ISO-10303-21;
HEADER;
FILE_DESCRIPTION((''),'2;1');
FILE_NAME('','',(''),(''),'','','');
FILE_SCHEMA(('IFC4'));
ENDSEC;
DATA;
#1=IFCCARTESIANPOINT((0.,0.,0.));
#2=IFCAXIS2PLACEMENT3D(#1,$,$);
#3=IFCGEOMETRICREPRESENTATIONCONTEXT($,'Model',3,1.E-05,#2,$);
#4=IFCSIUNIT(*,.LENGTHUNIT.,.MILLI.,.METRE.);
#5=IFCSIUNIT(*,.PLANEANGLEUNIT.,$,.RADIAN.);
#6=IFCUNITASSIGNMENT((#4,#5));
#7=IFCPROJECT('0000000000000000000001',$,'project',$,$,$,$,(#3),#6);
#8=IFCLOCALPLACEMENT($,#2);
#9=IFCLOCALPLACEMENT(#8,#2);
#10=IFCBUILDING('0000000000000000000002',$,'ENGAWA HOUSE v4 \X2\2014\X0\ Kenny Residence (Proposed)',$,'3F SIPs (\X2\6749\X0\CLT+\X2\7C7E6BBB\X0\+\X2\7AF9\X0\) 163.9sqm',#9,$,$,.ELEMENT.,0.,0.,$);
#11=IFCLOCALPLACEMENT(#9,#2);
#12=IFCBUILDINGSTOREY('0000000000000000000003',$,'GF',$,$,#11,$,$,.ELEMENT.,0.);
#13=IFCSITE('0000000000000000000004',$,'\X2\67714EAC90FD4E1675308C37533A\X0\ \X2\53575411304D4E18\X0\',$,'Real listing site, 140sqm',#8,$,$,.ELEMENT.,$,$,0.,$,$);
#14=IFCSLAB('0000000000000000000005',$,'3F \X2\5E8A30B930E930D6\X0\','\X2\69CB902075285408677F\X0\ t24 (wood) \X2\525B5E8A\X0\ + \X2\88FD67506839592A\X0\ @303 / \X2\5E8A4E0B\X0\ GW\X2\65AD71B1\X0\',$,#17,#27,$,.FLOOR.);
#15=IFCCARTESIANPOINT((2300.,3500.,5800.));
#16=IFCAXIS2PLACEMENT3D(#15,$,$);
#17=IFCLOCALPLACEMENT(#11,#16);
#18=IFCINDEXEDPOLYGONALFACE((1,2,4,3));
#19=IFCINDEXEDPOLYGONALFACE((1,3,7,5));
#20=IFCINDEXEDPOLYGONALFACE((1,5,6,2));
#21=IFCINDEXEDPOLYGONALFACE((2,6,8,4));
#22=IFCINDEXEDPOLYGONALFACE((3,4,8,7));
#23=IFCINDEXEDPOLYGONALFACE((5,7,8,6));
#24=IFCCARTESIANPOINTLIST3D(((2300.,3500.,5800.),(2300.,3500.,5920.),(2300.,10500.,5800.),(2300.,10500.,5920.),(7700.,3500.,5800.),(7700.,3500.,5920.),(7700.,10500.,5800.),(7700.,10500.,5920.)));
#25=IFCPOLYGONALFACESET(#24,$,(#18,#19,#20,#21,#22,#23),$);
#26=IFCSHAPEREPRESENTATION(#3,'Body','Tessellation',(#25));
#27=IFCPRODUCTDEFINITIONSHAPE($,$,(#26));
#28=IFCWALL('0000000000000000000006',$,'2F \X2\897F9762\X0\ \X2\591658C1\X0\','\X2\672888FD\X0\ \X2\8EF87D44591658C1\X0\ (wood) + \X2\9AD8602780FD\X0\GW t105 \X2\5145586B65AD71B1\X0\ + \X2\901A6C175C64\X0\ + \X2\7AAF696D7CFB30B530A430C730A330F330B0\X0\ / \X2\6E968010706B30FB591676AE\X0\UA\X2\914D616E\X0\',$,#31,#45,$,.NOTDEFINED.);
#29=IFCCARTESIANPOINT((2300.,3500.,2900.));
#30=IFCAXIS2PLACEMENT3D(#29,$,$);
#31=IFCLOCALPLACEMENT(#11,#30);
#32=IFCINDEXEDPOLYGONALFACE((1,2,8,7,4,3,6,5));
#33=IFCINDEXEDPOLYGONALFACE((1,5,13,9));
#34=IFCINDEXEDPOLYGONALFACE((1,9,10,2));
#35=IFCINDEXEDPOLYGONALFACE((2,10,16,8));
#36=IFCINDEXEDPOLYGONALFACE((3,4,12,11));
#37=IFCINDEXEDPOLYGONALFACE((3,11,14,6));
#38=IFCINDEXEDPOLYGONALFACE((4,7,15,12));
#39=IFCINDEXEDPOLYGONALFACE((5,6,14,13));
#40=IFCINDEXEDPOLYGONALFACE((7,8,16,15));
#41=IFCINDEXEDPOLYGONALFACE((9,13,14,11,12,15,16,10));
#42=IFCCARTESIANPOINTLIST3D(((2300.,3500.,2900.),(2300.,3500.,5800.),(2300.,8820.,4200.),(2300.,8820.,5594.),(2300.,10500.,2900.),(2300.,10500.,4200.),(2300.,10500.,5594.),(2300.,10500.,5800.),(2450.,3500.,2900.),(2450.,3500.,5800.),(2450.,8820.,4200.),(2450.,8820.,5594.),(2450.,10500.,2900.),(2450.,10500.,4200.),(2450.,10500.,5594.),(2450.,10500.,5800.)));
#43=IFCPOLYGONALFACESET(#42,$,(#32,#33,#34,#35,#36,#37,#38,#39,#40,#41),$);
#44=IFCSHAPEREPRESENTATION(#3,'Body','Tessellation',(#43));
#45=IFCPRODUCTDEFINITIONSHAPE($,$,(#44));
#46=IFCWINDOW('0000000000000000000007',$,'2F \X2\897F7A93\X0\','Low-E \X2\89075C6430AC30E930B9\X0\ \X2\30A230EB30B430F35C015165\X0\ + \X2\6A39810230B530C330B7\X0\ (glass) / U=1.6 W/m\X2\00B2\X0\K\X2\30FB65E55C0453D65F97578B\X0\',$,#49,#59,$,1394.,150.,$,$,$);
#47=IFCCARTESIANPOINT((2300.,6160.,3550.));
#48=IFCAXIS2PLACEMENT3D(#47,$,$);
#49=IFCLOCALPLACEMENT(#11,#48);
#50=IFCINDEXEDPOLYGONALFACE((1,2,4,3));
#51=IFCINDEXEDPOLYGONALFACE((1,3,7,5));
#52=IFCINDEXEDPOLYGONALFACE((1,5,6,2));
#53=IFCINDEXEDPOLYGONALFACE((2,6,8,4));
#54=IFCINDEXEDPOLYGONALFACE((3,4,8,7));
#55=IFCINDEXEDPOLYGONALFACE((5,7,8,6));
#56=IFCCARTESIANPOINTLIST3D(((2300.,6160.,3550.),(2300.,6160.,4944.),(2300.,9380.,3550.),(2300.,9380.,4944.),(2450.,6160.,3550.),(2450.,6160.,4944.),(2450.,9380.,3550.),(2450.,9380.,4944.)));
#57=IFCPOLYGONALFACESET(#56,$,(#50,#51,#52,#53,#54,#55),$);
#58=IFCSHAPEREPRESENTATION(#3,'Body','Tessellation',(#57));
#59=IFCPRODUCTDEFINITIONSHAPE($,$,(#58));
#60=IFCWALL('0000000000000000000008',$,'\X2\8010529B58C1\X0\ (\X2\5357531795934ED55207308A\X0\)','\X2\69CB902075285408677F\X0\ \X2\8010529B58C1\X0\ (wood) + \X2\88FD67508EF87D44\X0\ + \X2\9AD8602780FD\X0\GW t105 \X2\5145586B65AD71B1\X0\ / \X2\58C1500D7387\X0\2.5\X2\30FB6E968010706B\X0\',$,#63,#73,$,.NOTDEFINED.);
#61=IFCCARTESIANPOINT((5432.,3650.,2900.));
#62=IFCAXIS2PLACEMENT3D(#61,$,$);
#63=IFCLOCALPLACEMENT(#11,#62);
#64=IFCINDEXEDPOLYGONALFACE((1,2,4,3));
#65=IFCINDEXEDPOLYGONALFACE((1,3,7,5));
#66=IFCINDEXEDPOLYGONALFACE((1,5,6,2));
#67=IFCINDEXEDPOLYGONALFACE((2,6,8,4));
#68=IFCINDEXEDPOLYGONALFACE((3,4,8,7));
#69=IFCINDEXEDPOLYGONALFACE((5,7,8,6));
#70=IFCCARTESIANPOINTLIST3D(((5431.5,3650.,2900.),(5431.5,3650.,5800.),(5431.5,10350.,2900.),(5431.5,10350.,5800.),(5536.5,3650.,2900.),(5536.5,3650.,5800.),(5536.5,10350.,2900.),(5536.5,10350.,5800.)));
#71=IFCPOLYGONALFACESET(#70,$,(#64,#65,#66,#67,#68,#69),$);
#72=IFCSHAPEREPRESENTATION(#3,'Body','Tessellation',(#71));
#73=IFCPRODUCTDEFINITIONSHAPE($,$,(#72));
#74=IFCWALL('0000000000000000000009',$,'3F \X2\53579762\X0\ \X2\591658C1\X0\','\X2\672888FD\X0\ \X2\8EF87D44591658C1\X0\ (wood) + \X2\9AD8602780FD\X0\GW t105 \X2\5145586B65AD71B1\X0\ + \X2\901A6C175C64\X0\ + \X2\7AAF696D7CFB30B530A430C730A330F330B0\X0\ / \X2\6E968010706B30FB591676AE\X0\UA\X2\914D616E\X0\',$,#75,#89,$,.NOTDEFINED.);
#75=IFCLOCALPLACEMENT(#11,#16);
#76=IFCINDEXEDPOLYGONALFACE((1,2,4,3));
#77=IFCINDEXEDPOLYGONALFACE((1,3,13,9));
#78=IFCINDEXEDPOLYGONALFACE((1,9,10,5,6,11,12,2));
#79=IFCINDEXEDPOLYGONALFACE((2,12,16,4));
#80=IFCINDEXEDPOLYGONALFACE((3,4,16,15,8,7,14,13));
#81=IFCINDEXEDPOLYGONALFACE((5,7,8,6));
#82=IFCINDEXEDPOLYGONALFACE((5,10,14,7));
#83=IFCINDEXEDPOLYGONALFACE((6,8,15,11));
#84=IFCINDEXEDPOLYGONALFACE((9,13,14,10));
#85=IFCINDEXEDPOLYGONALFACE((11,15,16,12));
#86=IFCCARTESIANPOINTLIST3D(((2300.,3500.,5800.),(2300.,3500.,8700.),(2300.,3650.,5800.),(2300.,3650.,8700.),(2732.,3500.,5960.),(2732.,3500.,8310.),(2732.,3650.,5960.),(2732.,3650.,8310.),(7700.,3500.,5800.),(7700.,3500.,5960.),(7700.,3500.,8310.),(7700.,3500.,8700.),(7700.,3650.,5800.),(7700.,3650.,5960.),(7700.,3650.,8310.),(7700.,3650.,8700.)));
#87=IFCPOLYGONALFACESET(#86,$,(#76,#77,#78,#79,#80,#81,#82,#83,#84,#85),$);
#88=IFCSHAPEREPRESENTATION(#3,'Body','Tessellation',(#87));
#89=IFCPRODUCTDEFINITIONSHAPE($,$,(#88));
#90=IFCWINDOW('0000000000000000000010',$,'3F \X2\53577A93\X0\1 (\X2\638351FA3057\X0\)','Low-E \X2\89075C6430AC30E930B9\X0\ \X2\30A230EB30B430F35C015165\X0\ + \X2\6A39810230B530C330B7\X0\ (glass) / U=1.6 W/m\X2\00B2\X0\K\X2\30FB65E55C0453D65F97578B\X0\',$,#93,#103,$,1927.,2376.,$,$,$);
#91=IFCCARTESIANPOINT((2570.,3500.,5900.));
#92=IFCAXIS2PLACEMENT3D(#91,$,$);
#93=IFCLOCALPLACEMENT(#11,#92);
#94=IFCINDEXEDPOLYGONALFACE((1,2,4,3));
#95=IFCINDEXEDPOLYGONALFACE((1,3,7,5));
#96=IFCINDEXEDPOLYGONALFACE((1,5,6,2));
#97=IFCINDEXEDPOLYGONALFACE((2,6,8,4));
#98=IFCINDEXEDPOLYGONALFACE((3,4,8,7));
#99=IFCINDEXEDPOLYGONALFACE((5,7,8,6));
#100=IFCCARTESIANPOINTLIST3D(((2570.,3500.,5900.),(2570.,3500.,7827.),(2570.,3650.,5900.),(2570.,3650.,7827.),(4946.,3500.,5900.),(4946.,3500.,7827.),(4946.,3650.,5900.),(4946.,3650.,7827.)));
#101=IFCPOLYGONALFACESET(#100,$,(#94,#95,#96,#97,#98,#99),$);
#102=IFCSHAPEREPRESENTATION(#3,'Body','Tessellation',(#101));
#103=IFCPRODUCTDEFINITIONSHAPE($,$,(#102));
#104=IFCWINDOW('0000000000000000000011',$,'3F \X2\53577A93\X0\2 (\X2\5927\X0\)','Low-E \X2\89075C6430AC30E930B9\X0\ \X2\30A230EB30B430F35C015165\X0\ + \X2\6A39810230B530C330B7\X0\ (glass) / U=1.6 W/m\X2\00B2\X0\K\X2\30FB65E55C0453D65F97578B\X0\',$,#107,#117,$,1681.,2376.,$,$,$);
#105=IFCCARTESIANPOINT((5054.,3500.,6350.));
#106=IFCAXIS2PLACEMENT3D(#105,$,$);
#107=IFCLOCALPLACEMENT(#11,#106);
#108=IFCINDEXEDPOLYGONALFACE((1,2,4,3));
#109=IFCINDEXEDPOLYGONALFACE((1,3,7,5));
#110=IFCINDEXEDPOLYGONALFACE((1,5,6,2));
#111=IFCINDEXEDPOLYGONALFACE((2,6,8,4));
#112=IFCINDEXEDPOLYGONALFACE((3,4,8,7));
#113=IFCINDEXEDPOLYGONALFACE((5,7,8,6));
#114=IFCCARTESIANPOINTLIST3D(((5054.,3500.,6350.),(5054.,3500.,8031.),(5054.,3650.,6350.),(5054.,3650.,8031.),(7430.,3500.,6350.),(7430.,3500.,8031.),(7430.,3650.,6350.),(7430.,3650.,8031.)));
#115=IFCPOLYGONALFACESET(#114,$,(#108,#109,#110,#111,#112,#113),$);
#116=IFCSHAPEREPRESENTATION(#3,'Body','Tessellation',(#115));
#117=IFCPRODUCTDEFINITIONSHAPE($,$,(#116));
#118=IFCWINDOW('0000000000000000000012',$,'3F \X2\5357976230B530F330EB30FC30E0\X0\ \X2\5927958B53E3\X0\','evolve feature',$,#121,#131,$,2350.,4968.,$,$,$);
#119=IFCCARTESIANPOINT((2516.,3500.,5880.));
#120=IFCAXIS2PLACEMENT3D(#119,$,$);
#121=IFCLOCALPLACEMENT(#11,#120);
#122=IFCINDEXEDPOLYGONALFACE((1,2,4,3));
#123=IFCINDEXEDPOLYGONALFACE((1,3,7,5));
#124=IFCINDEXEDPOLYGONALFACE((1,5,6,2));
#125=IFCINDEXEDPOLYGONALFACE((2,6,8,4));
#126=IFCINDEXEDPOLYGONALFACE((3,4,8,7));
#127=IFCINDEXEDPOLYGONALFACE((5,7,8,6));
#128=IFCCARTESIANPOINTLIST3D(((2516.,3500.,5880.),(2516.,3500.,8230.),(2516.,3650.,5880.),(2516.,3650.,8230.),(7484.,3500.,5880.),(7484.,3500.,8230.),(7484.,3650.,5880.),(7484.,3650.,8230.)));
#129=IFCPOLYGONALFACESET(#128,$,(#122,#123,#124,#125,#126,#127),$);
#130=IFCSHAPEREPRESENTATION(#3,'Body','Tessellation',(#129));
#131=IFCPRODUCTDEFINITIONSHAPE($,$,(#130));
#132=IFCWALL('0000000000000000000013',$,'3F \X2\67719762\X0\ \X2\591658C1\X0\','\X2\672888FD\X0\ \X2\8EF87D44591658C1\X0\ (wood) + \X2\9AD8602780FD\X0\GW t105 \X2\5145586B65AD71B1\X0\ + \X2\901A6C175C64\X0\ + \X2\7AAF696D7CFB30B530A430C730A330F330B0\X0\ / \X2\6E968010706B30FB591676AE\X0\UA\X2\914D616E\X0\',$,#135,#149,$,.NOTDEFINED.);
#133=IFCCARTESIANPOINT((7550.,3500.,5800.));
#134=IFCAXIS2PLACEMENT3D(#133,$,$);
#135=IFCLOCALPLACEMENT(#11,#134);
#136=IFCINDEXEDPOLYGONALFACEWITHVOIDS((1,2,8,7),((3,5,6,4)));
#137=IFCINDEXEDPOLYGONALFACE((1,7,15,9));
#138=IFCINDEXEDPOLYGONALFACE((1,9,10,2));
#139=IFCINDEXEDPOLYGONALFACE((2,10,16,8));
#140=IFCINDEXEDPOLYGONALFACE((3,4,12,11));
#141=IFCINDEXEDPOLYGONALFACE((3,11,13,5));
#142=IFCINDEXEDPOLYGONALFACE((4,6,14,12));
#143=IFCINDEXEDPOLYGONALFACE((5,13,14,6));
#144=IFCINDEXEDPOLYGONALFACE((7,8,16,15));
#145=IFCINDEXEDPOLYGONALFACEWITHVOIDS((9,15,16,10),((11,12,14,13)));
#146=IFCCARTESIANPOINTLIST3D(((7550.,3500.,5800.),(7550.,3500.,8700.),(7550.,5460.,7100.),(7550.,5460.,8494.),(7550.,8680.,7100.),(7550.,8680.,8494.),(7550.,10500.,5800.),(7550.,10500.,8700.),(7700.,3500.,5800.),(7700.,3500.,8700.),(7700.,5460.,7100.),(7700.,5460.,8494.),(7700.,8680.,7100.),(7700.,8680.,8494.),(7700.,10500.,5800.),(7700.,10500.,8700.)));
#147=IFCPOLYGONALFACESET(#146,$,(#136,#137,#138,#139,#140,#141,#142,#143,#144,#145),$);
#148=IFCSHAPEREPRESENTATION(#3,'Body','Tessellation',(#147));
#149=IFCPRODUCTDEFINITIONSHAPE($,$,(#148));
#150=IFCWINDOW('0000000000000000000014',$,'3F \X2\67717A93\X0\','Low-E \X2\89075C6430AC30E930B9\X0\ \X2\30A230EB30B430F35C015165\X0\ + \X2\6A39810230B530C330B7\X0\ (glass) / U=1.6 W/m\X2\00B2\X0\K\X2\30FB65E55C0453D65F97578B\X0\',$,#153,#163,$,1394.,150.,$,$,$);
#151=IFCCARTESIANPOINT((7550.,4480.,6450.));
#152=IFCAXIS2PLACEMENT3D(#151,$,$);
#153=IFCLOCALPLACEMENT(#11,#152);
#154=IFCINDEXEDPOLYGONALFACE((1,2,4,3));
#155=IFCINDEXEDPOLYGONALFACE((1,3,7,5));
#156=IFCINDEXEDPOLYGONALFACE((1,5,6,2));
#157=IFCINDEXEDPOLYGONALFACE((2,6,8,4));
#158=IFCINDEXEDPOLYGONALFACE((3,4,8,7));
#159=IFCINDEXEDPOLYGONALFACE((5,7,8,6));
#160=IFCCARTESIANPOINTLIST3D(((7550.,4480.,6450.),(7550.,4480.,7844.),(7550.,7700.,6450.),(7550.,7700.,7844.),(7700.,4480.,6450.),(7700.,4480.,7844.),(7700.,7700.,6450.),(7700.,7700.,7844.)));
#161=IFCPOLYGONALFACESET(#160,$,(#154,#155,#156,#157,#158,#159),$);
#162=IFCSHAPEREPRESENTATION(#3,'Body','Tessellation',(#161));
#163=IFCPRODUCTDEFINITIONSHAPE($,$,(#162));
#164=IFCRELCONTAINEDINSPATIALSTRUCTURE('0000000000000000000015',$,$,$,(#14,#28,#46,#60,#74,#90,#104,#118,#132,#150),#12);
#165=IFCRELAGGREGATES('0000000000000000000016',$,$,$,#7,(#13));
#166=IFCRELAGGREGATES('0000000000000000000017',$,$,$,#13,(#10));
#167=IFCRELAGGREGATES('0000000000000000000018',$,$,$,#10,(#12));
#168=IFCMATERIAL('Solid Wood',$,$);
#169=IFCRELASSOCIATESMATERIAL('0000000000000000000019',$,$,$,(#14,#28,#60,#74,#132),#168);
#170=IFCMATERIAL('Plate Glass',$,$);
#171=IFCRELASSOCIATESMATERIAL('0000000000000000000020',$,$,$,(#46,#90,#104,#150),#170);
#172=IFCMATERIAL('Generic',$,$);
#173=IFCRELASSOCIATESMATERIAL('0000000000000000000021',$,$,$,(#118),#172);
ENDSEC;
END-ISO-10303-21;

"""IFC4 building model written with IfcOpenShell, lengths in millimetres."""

from ifc_helpers import new_model, si_unit, frame, frame_2d, origin, place, context, project, spatial, rectangle, extrude, material, element, fill, save


model = new_model("IFC4")

# Units and contexts
model_context = context("Model", 3, precision=1e-05, world=origin())
ifc_project = project(units=[si_unit("LENGTHUNIT", "METRE", prefix="MILLI"), si_unit("PLANEANGLEUNIT", "RADIAN")], contexts=[model_context])

# Site, building, storey
site_placement = place(None, origin())
site = spatial("IfcSite", under=ifc_project, at=site_placement, Name="東京都世田谷区 南向き丘", ObjectType="Real listing site, 140sqm", CompositionType="ELEMENT", RefElevation=0.0)
building_placement = place(site_placement, origin())
building = spatial("IfcBuilding", under=site, at=building_placement, Name="ENGAWA HOUSE v4 — Kenny Residence (Proposed)", ObjectType="3F SIPs (杉CLT+籾殻+竹) 163.9sqm", CompositionType="ELEMENT", ElevationOfRefHeight=0.0, ElevationOfTerrain=0.0)
storey_placement = place(building_placement, origin())
storey = spatial("IfcBuildingStorey", under=building, at=storey_placement, Name="GF", CompositionType="ELEMENT", Elevation=0.0)

# Slab
ifc_material_1 = material(Name="Solid Wood")
slab_placement = place(storey_placement, frame((2300.0, 3500.0, 5800.0)))
element("IfcSlab", 1, at=slab_placement, inside=storey, material=ifc_material_1, Name="3F 床スラブ", Description="構造用合板 t24 (wood) 剛床 + 製材根太 @303 / 床下 GW断熱", PredefinedType="FLOOR", context=model_context, shape_type="SweptSolid", body=[
    extrude(rectangle(XDim=5400.0, YDim=7000.0, at=frame_2d((2700.0, 3500.0))), frame((2300.0, 3500.0, 5800.0)), (0.0, 0.0, 1.0), 120.0),
])

# Wall, opening, window
wall_1_placement = place(storey_placement, frame((2300.0, 3500.0, 2900.0)))
wall_1 = element("IfcWall", 2, at=wall_1_placement, inside=storey, material=ifc_material_1, Name="2F 西面 外壁", Description="木製 軸組外壁 (wood) + 高性能GW t105 充填断熱 + 通気層 + 窯業系サイディング / 準耐火・外皮UA配慮", PredefinedType="NOTDEFINED", context=model_context, shape_type="SweptSolid", body=[
    extrude(rectangle(XDim=150.0, YDim=7000.0, at=frame_2d((75.0, 3500.0))), frame((2300.0, 3500.0, 2900.0)), (0.0, 0.0, 1.0), 2900.0),
])
opening_1_placement = place(storey_placement, frame((2300.0, 6160.0, 3550.0)))
opening_1 = element("IfcOpeningElement", 3, at=opening_1_placement, cuts=wall_1, PredefinedType="NOTDEFINED", context=model_context, shape_type="SweptSolid", body=[
    extrude(rectangle(XDim=150.0, YDim=3220.0, at=frame_2d((75.0, 1610.0))), frame((2300.0, 6160.0, 3550.0)), (0.0, 0.0, 1.0), 1394.0),
])
ifc_material_2 = material(Name="Plate Glass")
window_1_placement = place(storey_placement, frame((2300.0, 6160.0, 3550.0)))
window_1 = element("IfcWindow", 4, at=window_1_placement, inside=storey, material=ifc_material_2, Name="2F 西窓", Description="Low-E 複層ガラス アルゴン封入 + 樹脂サッシ (glass) / U=1.6 W/m²K・日射取得型", OverallHeight=1394.0, OverallWidth=150.0, context=model_context, shape_type="SweptSolid", body=[
    extrude(rectangle(XDim=150.0, YDim=3220.0, at=frame_2d((75.0, 1610.0))), frame((2300.0, 6160.0, 3550.0)), (0.0, 0.0, 1.0), 1394.0),
])
fill(opening_1, window_1)

# Wall
wall_2_placement = place(storey_placement, frame((5432.0, 3650.0, 2900.0)))
element("IfcWall", 5, at=wall_2_placement, inside=storey, material=ifc_material_1, Name="耐力壁 (南北間仕切り)", Description="構造用合板 耐力壁 (wood) + 製材軸組 + 高性能GW t105 充填断熱 / 壁倍率2.5・準耐火", PredefinedType="NOTDEFINED", context=model_context, shape_type="SweptSolid", body=[
    extrude(rectangle(XDim=105.0, YDim=6700.0, at=frame_2d((52.0, 3350.0))), frame((5432.0, 3650.0, 2900.0)), (0.0, 0.0, 1.0), 2900.0),
])

# Wall, openings, windows
wall_3_placement = place(storey_placement, frame((2300.0, 3500.0, 5800.0)))
wall_3 = element("IfcWall", 6, at=wall_3_placement, inside=storey, material=ifc_material_1, Name="3F 南面 外壁", Description="木製 軸組外壁 (wood) + 高性能GW t105 充填断熱 + 通気層 + 窯業系サイディング / 準耐火・外皮UA配慮", PredefinedType="NOTDEFINED", context=model_context, shape_type="SweptSolid", body=[
    extrude(rectangle(XDim=5400.0, YDim=150.0, at=frame_2d((2700.0, 75.0))), frame((2300.0, 3500.0, 5800.0)), (0.0, 0.0, 1.0), 2900.0),
])
opening_2_placement = place(storey_placement, frame((2570.0, 3500.0, 5900.0)))
opening_2 = element("IfcOpeningElement", 7, at=opening_2_placement, cuts=wall_3, PredefinedType="NOTDEFINED", context=model_context, shape_type="SweptSolid", body=[
    extrude(rectangle(XDim=2376.0, YDim=150.0, at=frame_2d((1188.0, 75.0))), frame((2570.0, 3500.0, 5900.0)), (0.0, 0.0, 1.0), 1927.0),
])
opening_3_placement = place(storey_placement, frame((5054.0, 3500.0, 6350.0)))
opening_3 = element("IfcOpeningElement", 8, at=opening_3_placement, cuts=wall_3, PredefinedType="NOTDEFINED", context=model_context, shape_type="SweptSolid", body=[
    extrude(rectangle(XDim=2376.0, YDim=150.0, at=frame_2d((1188.0, 75.0))), frame((5054.0, 3500.0, 6350.0)), (0.0, 0.0, 1.0), 1681.0),
])
opening_4_placement = place(storey_placement, frame((2516.0, 3500.0, 5880.0)))
opening_4 = element("IfcOpeningElement", 9, at=opening_4_placement, cuts=wall_3, PredefinedType="NOTDEFINED", context=model_context, shape_type="SweptSolid", body=[
    extrude(rectangle(XDim=4968.0, YDim=150.0, at=frame_2d((2484.0, 75.0))), frame((2516.0, 3500.0, 5880.0)), (0.0, 0.0, 1.0), 2350.0),
])
window_2_placement = place(storey_placement, frame((2570.0, 3500.0, 5900.0)))
window_2 = element("IfcWindow", 10, at=window_2_placement, inside=storey, material=ifc_material_2, Name="3F 南窓1 (掃出し)", Description="Low-E 複層ガラス アルゴン封入 + 樹脂サッシ (glass) / U=1.6 W/m²K・日射取得型", OverallHeight=1927.0, OverallWidth=2376.0, context=model_context, shape_type="SweptSolid", body=[
    extrude(rectangle(XDim=2376.0, YDim=150.0, at=frame_2d((1188.0, 75.0))), frame((2570.0, 3500.0, 5900.0)), (0.0, 0.0, 1.0), 1927.0),
])
fill(opening_2, window_2)
window_3_placement = place(storey_placement, frame((5054.0, 3500.0, 6350.0)))
window_3 = element("IfcWindow", 11, at=window_3_placement, inside=storey, material=ifc_material_2, Name="3F 南窓2 (大)", Description="Low-E 複層ガラス アルゴン封入 + 樹脂サッシ (glass) / U=1.6 W/m²K・日射取得型", OverallHeight=1681.0, OverallWidth=2376.0, context=model_context, shape_type="SweptSolid", body=[
    extrude(rectangle(XDim=2376.0, YDim=150.0, at=frame_2d((1188.0, 75.0))), frame((5054.0, 3500.0, 6350.0)), (0.0, 0.0, 1.0), 1681.0),
])
fill(opening_3, window_3)
ifc_material_3 = material(Name="Generic")
window_4_placement = place(storey_placement, frame((2516.0, 3500.0, 5880.0)))
window_4 = element("IfcWindow", 12, at=window_4_placement, inside=storey, material=ifc_material_3, Name="3F 南面サンルーム 大開口", Description="evolve feature", OverallHeight=2350.0, OverallWidth=4968.0, context=model_context, shape_type="SweptSolid", body=[
    extrude(rectangle(XDim=4968.0, YDim=150.0, at=frame_2d((2484.0, 75.0))), frame((2516.0, 3500.0, 5880.0)), (0.0, 0.0, 1.0), 2350.0),
])
fill(opening_4, window_4)

# Wall, opening, window
wall_4_placement = place(storey_placement, frame((7550.0, 3500.0, 5800.0)))
wall_4 = element("IfcWall", 13, at=wall_4_placement, inside=storey, material=ifc_material_1, Name="3F 東面 外壁", Description="木製 軸組外壁 (wood) + 高性能GW t105 充填断熱 + 通気層 + 窯業系サイディング / 準耐火・外皮UA配慮", PredefinedType="NOTDEFINED", context=model_context, shape_type="SweptSolid", body=[
    extrude(rectangle(XDim=150.0, YDim=7000.0, at=frame_2d((75.0, 3500.0))), frame((7550.0, 3500.0, 5800.0)), (0.0, 0.0, 1.0), 2900.0),
])
opening_5_placement = place(storey_placement, frame((7550.0, 4480.0, 6450.0)))
opening_5 = element("IfcOpeningElement", 14, at=opening_5_placement, cuts=wall_4, PredefinedType="NOTDEFINED", context=model_context, shape_type="SweptSolid", body=[
    extrude(rectangle(XDim=150.0, YDim=3220.0, at=frame_2d((75.0, 1610.0))), frame((7550.0, 4480.0, 6450.0)), (0.0, 0.0, 1.0), 1394.0),
])
window_5_placement = place(storey_placement, frame((7550.0, 4480.0, 6450.0)))
window_5 = element("IfcWindow", 15, at=window_5_placement, inside=storey, material=ifc_material_2, Name="3F 東窓", Description="Low-E 複層ガラス アルゴン封入 + 樹脂サッシ (glass) / U=1.6 W/m²K・日射取得型", OverallHeight=1394.0, OverallWidth=150.0, context=model_context, shape_type="SweptSolid", body=[
    extrude(rectangle(XDim=150.0, YDim=3220.0, at=frame_2d((75.0, 1610.0))), frame((7550.0, 4480.0, 6450.0)), (0.0, 0.0, 1.0), 1394.0),
])
fill(opening_5, window_5)

save(model, "model.ifc")
